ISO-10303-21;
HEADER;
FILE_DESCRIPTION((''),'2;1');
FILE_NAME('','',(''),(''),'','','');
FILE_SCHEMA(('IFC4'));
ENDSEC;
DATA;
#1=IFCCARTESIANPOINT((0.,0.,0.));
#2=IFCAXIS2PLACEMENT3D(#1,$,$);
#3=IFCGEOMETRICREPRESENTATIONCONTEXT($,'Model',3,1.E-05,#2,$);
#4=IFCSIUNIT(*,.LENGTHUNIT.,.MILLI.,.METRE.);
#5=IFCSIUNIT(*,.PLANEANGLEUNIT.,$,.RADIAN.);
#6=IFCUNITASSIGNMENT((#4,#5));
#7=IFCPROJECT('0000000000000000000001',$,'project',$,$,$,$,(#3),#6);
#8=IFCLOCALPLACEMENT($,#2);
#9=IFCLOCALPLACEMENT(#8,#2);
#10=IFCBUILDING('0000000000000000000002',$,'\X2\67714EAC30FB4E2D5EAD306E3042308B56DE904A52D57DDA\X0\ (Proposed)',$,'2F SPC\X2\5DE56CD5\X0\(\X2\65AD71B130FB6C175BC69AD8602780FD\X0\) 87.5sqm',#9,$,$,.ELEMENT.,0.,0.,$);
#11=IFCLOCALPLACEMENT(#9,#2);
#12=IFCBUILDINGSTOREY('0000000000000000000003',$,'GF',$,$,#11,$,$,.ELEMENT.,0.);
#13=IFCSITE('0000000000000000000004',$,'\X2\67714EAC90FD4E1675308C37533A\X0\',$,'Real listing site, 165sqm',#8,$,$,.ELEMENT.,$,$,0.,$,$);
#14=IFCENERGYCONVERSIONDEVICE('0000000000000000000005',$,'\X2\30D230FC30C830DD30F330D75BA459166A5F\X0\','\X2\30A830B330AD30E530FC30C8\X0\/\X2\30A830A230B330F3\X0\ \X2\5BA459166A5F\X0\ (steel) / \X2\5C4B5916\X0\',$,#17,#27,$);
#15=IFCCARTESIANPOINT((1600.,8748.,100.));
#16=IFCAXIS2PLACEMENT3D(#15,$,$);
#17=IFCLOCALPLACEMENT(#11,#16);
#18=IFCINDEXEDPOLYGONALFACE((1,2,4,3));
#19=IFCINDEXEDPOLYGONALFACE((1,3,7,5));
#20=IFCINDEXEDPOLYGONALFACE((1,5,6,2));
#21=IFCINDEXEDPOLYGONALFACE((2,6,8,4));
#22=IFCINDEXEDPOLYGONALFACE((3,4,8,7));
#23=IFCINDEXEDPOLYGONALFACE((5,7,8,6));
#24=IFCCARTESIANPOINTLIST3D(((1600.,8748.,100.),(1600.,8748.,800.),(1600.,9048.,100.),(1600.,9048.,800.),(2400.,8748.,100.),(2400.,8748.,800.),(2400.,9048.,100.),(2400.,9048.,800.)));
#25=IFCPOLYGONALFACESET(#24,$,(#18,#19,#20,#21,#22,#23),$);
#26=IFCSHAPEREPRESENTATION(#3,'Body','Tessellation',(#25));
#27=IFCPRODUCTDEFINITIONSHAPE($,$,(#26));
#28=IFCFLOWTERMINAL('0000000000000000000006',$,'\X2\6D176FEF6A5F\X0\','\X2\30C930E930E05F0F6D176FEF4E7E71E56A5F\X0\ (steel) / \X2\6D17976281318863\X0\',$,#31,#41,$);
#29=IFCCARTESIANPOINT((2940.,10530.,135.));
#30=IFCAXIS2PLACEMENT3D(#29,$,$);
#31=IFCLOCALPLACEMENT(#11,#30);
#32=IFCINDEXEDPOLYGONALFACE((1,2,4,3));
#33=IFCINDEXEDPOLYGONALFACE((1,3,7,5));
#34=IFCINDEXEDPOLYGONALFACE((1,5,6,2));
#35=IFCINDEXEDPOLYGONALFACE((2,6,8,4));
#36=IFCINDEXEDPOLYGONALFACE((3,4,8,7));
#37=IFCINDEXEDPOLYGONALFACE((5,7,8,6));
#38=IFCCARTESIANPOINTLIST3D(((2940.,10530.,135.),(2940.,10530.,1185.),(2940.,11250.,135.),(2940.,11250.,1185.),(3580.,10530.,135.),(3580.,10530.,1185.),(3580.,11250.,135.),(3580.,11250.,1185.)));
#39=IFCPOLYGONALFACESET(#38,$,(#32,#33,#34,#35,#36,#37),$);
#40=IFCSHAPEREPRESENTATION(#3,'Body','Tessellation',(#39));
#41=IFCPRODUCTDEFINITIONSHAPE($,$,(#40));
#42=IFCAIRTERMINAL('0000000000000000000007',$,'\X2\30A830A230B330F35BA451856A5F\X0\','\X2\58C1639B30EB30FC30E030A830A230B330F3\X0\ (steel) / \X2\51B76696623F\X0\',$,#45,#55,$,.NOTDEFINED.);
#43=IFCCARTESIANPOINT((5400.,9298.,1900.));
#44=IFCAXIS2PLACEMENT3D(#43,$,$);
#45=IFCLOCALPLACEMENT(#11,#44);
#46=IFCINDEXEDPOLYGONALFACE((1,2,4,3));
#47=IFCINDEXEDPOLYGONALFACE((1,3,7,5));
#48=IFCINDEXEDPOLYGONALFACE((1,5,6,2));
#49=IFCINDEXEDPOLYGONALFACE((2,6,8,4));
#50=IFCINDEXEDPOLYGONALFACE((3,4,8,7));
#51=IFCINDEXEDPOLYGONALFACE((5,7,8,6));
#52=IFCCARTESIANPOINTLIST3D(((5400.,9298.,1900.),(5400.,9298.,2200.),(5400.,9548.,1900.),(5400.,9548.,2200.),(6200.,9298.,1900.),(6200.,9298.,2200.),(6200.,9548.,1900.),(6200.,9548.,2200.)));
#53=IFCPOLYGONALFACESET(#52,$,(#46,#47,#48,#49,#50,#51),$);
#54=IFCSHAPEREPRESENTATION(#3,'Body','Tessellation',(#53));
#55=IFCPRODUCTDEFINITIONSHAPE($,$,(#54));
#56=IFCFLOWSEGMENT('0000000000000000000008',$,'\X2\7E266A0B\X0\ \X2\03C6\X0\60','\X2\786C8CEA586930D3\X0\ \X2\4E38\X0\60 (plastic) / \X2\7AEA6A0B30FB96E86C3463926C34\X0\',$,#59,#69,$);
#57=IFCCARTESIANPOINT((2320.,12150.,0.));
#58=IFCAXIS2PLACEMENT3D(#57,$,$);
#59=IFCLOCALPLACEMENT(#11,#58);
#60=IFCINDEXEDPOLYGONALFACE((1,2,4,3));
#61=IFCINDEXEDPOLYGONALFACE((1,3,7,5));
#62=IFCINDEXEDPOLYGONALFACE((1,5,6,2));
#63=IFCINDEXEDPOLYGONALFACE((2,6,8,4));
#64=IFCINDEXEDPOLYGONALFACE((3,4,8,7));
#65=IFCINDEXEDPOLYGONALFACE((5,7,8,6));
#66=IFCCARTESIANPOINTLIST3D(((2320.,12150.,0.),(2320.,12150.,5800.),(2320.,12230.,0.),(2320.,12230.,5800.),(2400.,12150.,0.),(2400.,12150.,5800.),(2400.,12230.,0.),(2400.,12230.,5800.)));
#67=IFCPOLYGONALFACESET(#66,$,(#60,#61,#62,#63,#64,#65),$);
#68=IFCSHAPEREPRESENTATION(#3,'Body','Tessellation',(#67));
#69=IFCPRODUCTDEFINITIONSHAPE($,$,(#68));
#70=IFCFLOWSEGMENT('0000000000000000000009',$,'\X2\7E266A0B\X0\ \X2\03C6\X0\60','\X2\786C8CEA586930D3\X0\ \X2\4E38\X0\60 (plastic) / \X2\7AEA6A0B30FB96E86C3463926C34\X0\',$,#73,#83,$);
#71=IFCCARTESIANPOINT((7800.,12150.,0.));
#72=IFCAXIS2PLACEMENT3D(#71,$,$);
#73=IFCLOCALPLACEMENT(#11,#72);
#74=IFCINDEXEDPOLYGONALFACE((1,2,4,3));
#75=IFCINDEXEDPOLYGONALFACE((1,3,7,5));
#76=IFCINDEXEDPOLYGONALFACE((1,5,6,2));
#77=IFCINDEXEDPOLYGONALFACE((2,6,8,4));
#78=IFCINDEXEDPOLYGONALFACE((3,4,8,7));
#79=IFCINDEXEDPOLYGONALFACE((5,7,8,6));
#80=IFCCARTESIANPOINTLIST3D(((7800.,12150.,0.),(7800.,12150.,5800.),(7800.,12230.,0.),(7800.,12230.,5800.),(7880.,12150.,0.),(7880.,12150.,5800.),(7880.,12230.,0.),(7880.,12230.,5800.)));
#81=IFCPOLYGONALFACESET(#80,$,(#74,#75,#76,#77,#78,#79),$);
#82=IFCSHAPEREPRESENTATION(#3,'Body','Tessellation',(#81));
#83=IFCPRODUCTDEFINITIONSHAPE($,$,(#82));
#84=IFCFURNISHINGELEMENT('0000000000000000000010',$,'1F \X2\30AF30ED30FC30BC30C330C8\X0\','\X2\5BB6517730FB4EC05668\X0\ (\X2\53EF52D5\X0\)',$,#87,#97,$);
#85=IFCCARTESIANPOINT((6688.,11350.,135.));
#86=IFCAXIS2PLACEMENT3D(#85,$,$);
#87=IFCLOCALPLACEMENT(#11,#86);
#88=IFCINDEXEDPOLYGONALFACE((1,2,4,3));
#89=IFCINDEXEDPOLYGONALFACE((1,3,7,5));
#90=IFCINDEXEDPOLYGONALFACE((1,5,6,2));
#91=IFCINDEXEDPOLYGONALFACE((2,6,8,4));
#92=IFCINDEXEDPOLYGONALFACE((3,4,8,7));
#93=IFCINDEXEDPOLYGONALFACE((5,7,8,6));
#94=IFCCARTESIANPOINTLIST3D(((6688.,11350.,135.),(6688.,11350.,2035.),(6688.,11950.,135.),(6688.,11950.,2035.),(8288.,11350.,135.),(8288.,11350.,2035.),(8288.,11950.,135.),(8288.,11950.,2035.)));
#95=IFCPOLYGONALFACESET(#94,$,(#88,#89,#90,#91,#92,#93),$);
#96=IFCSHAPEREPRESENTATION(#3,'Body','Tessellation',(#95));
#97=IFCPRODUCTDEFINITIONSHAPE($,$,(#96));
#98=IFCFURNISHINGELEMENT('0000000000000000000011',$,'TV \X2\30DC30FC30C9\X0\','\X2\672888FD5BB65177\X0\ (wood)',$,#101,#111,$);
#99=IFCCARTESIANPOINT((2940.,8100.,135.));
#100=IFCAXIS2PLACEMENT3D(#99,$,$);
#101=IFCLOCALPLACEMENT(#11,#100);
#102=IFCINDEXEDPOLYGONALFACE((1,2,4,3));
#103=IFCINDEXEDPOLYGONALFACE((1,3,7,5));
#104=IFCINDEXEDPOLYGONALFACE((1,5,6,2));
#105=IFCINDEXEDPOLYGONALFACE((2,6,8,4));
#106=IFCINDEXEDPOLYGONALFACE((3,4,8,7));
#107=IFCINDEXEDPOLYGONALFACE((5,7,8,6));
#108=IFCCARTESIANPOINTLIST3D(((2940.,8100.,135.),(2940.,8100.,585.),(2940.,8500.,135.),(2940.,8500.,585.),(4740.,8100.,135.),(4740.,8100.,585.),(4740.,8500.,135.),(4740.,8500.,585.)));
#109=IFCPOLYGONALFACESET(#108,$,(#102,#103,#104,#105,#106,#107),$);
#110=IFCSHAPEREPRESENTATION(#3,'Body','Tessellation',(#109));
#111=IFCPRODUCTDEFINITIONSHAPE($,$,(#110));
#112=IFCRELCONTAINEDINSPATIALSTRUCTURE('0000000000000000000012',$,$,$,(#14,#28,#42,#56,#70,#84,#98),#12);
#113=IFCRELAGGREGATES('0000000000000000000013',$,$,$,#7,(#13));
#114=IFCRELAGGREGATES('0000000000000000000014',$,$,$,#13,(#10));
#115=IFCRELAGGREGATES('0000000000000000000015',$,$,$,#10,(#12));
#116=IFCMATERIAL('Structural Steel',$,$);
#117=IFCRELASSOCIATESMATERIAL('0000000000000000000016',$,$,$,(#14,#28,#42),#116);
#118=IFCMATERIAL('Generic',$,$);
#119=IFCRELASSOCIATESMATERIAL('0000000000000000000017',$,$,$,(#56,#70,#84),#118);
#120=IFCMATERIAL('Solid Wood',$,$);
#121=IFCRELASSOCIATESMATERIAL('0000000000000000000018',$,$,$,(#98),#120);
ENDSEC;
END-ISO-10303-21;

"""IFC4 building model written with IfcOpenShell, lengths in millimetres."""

from ifc_helpers import new_model, si_unit, frame, frame_2d, origin, place, context, project, spatial, rectangle, extrude, material, element, save


model = new_model("IFC4")

# Units and contexts
model_context = context("Model", 3, precision=1e-05, world=origin())
ifc_project = project(units=[si_unit("LENGTHUNIT", "METRE", prefix="MILLI"), si_unit("PLANEANGLEUNIT", "RADIAN")], contexts=[model_context])

# Site, building, storey
site_placement = place(None, origin())
site = spatial("IfcSite", under=ifc_project, at=site_placement, Name="東京都世田谷区", ObjectType="Real listing site, 165sqm", CompositionType="ELEMENT", RefElevation=0.0)
building_placement = place(site_placement, origin())
building = spatial("IfcBuilding", under=site, at=building_placement, Name="東京・中庭のある回遊動線 (Proposed)", ObjectType="2F SPC工法(断熱・気密高性能) 87.5sqm", CompositionType="ELEMENT", ElevationOfRefHeight=0.0, ElevationOfTerrain=0.0)
storey_placement = place(building_placement, origin())
storey = spatial("IfcBuildingStorey", under=building, at=storey_placement, Name="GF", CompositionType="ELEMENT", Elevation=0.0)

# Shared definitions
ifc_material_1 = material(Name="Solid Wood")

# Shared definitions
ifc_material_2 = material(Name="Generic")

# Shared definitions
ifc_material_3 = material(Name="Structural Steel")

# Energy conversion device
energy_conversion_device_placement = place(storey_placement, frame((1600.0, 8748.0, 100.0)))
element("IfcEnergyConversionDevice", 1, at=energy_conversion_device_placement, inside=storey, material=ifc_material_3, Name="ヒートポンプ室外機", Description="エコキュート/エアコン 室外機 (steel) / 屋外", context=model_context, shape_type="SweptSolid", body=[
    extrude(rectangle(XDim=800.0, YDim=300.0, at=frame_2d((400.0, 150.0))), frame((1600.0, 8748.0, 100.0)), (0.0, 0.0, 1.0), 700.0),
])

# Flow terminal
flow_terminal_placement = place(storey_placement, frame((2940.0, 10530.0, 135.0)))
element("IfcFlowTerminal", 2, at=flow_terminal_placement, inside=storey, material=ifc_material_3, Name="洗濯機", Description="ドラム式洗濯乾燥機 (steel) / 洗面脱衣", context=model_context, shape_type="SweptSolid", body=[
    extrude(rectangle(XDim=640.0, YDim=720.0, at=frame_2d((320.0, 360.0))), frame((2940.0, 10530.0, 135.0)), (0.0, 0.0, 1.0), 1050.0),
])

# Air terminal
air_terminal_placement = place(storey_placement, frame((5400.0, 9298.0, 1900.0)))
element("IfcAirTerminal", 3, at=air_terminal_placement, inside=storey, material=ifc_material_3, Name="エアコン室内機", Description="壁掛ルームエアコン (steel) / 冷暖房", PredefinedType="NOTDEFINED", context=model_context, shape_type="SweptSolid", body=[
    extrude(rectangle(XDim=800.0, YDim=250.0, at=frame_2d((400.0, 125.0))), frame((5400.0, 9298.0, 1900.0)), (0.0, 0.0, 1.0), 300.0),
])

# Flow segments
flow_segment_1_placement = place(storey_placement, frame((2320.0, 12150.0, 0.0)))
element("IfcFlowSegment", 4, at=flow_segment_1_placement, inside=storey, material=ifc_material_2, Name="縦樋 φ60", Description="硬質塩ビ 丸60 (plastic) / 竪樋・雨水排水", context=model_context, shape_type="SweptSolid", body=[
    extrude(rectangle(XDim=80.0, YDim=80.0, at=frame_2d((40.0, 40.0))), frame((2320.0, 12150.0, 0.0)), (0.0, 0.0, 1.0), 5800.0),
])
flow_segment_2_placement = place(storey_placement, frame((7800.0, 12150.0, 0.0)))
element("IfcFlowSegment", 5, at=flow_segment_2_placement, inside=storey, material=ifc_material_2, Name="縦樋 φ60", Description="硬質塩ビ 丸60 (plastic) / 竪樋・雨水排水", context=model_context, shape_type="SweptSolid", body=[
    extrude(rectangle(XDim=80.0, YDim=80.0, at=frame_2d((40.0, 40.0))), frame((7800.0, 12150.0, 0.0)), (0.0, 0.0, 1.0), 5800.0),
])

# Furnishing elements
furnishing_1_placement = place(storey_placement, frame((6688.0, 11350.0, 135.0)))
element("IfcFurnishingElement", 6, at=furnishing_1_placement, inside=storey, material=ifc_material_2, Name="1F クローゼット", Description="家具・什器 (可動)", context=model_context, shape_type="SweptSolid", body=[
    extrude(rectangle(XDim=1600.0, YDim=600.0, at=frame_2d((800.0, 300.0))), frame((6688.0, 11350.0, 135.0)), (0.0, 0.0, 1.0), 1900.0),
])
furnishing_2_placement = place(storey_placement, frame((2940.0, 8100.0, 135.0)))
element("IfcFurnishingElement", 7, at=furnishing_2_placement, inside=storey, material=ifc_material_1, Name="TV ボード", Description="木製家具 (wood)", context=model_context, shape_type="SweptSolid", body=[
    extrude(rectangle(XDim=1800.0, YDim=400.0, at=frame_2d((900.0, 200.0))), frame((2940.0, 8100.0, 135.0)), (0.0, 0.0, 1.0), 450.0),
])

save(model, "model.ifc")
